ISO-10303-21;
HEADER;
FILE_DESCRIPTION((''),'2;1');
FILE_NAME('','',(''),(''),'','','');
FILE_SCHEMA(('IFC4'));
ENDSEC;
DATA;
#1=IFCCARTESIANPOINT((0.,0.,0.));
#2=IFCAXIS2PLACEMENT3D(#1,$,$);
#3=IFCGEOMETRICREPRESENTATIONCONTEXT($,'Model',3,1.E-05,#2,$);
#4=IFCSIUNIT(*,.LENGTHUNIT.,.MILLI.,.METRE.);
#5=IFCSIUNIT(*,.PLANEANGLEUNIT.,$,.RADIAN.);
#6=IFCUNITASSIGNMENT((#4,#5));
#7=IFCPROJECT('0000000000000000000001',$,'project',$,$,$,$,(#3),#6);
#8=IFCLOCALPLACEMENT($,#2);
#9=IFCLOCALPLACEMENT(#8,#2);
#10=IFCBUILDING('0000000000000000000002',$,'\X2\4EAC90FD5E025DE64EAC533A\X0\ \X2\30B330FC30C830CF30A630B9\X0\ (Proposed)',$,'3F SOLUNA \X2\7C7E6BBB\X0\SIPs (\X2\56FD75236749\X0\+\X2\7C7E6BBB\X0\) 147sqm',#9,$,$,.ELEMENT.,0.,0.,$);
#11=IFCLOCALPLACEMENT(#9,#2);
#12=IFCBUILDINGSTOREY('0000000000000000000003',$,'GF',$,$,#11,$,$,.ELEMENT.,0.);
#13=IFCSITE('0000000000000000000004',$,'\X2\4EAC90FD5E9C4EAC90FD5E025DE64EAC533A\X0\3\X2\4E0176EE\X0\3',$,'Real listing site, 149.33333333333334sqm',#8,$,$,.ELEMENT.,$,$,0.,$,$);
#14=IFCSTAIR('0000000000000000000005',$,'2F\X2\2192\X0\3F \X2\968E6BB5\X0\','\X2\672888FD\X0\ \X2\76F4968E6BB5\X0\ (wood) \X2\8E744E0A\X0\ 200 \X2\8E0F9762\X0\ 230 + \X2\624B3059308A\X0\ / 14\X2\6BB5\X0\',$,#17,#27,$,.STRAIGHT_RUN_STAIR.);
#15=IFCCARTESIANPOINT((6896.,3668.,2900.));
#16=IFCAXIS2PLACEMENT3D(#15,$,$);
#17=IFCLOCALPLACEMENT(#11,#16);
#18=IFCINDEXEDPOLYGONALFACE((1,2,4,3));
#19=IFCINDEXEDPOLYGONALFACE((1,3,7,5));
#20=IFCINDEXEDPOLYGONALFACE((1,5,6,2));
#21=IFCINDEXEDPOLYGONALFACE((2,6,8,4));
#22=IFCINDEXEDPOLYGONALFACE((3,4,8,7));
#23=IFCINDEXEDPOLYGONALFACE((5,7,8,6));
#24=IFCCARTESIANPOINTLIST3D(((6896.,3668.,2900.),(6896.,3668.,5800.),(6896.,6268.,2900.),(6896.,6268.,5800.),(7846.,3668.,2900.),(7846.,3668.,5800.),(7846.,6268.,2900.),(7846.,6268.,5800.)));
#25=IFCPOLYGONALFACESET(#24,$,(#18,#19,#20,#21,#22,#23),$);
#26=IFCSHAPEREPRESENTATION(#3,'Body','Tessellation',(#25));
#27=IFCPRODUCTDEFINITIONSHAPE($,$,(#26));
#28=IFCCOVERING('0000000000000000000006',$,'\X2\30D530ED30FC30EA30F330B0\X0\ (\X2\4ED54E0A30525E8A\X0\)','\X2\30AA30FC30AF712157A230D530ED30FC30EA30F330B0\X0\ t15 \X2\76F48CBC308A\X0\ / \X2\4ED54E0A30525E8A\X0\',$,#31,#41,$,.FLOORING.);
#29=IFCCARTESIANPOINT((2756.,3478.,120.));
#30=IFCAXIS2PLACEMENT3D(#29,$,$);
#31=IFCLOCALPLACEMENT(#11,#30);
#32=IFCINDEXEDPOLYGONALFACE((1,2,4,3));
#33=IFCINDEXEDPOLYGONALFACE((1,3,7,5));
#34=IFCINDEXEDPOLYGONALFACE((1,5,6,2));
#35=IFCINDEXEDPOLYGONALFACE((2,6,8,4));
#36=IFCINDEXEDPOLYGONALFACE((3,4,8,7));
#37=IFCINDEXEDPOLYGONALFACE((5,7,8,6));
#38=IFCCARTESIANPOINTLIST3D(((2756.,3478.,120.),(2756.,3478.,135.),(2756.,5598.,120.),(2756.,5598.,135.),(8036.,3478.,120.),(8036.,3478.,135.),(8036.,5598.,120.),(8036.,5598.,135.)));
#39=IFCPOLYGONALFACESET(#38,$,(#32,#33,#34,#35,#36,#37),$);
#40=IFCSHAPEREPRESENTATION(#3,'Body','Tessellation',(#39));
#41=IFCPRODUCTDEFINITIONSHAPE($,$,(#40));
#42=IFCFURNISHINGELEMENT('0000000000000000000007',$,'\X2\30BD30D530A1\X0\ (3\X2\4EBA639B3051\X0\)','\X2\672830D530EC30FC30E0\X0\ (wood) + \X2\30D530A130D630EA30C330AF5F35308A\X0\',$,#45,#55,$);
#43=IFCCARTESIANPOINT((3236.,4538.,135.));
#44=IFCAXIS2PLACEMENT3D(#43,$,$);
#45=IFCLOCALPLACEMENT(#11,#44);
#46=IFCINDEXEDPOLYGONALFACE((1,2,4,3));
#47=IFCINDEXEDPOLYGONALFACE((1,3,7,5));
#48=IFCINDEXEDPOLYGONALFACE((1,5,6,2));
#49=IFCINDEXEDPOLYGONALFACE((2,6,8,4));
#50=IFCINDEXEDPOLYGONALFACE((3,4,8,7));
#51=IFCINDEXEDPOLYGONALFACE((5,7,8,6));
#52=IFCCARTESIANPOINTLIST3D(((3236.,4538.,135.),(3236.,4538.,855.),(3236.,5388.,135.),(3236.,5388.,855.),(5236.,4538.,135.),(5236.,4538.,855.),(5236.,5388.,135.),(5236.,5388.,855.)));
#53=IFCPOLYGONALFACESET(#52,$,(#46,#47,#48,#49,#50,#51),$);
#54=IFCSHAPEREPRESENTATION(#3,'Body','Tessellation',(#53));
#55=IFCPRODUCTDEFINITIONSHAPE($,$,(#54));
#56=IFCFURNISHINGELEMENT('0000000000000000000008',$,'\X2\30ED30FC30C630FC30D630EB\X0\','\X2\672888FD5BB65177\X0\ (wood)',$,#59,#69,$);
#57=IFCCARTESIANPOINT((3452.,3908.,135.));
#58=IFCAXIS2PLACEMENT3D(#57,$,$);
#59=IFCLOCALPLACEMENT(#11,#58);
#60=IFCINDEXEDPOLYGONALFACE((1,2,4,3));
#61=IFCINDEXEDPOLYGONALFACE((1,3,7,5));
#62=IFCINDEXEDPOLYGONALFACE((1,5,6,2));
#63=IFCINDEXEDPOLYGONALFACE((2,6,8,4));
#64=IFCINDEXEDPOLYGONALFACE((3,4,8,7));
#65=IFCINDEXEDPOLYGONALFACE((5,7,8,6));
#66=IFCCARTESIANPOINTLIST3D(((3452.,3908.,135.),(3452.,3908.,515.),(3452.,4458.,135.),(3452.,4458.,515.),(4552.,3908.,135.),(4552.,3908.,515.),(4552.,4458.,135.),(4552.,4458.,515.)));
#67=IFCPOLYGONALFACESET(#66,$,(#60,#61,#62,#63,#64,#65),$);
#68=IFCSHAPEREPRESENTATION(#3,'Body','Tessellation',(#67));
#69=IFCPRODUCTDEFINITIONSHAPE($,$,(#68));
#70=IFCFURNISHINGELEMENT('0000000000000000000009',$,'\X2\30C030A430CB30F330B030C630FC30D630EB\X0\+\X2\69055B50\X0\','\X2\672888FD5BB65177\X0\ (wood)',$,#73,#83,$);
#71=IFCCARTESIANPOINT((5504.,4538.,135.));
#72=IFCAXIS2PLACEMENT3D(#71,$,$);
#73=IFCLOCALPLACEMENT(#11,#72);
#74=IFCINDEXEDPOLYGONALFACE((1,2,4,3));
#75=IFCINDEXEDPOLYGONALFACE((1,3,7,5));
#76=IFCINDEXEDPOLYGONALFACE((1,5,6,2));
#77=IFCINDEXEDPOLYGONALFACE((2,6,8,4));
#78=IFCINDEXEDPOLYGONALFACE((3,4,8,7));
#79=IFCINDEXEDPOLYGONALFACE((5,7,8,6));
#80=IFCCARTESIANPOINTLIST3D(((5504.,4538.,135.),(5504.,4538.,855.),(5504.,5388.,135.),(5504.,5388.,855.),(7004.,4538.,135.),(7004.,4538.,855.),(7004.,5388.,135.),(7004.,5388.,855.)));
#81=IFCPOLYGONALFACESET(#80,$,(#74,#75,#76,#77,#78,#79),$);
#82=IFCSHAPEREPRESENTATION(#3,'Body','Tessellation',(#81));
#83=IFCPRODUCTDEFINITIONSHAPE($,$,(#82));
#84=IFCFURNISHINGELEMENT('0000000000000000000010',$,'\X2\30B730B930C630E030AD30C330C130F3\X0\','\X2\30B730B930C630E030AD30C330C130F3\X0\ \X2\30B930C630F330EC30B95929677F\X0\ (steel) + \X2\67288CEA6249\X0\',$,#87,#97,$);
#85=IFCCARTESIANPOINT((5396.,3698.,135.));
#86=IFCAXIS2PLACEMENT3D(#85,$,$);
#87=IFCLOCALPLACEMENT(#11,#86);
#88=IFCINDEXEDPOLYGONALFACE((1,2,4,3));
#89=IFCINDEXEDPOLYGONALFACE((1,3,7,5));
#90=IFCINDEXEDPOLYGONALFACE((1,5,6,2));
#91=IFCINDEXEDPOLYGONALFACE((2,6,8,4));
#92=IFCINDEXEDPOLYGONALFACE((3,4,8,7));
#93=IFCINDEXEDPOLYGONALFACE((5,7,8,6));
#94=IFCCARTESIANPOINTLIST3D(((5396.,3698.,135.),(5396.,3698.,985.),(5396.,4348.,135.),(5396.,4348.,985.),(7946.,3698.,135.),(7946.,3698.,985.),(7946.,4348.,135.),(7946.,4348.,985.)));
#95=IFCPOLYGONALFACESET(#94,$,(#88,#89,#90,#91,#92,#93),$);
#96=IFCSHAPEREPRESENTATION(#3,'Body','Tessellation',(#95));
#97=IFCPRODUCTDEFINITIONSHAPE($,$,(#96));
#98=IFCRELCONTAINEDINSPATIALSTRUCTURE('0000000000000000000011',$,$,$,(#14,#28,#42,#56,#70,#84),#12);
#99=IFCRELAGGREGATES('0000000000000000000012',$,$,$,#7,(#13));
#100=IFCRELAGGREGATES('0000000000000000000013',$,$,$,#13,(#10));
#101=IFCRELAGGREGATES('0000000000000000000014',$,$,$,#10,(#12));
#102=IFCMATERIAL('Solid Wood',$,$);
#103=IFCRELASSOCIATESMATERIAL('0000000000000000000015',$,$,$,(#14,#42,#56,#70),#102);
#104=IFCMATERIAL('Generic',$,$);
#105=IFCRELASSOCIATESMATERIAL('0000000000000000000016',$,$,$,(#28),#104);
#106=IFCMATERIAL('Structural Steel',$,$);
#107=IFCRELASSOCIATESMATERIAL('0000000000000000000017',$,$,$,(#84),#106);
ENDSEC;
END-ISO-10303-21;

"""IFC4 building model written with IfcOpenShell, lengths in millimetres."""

from ifc_helpers import new_model, si_unit, frame, frame_2d, origin, place, context, project, spatial, rectangle, extrude, material, element, save


model = new_model("IFC4")

# Units and contexts
model_context = context("Model", 3, precision=1e-05, world=origin())
ifc_project = project(units=[si_unit("LENGTHUNIT", "METRE", prefix="MILLI"), si_unit("PLANEANGLEUNIT", "RADIAN")], contexts=[model_context])

# Site, building, storey
site_placement = place(None, origin())
site = spatial("IfcSite", under=ifc_project, at=site_placement, Name="京都府京都市左京区3丁目3", ObjectType="Real listing site, 149.33333333333334sqm", CompositionType="ELEMENT", RefElevation=0.0)
building_placement = place(site_placement, origin())
building = spatial("IfcBuilding", under=site, at=building_placement, Name="京都市左京区 コートハウス (Proposed)", ObjectType="3F SOLUNA 籾殻SIPs (国産杉+籾殻) 147sqm", CompositionType="ELEMENT", ElevationOfRefHeight=0.0, ElevationOfTerrain=0.0)
storey_placement = place(building_placement, origin())
storey = spatial("IfcBuildingStorey", under=building, at=storey_placement, Name="GF", CompositionType="ELEMENT", Elevation=0.0)

# Shared definitions
ifc_material_1 = material(Name="Solid Wood")
ifc_material_2 = material(Name="Generic")

# Stair
stair_1_placement = place(storey_placement, frame((6896.0, 3668.0, 2900.0)))
element("IfcStair", 1, at=stair_1_placement, inside=storey, material=ifc_material_1, Name="2F→3F 階段", Description="木製 直階段 (wood) 蹴上 200 踏面 230 + 手すり / 14段", PredefinedType="STRAIGHT_RUN_STAIR", context=model_context, shape_type="SweptSolid", body=[
    extrude(rectangle(XDim=950.0, YDim=2600.0, at=frame_2d((475.0, 1300.0))), frame((6896.0, 3668.0, 2900.0)), (0.0, 0.0, 1.0), 2900.0),
])

# Covering
covering_placement = place(storey_placement, frame((2756.0, 3478.0, 120.0)))
element("IfcCovering", 2, at=covering_placement, inside=storey, material=ifc_material_2, Name="フローリング (仕上げ床)", Description="オーク無垢フローリング t15 直貼り / 仕上げ床", PredefinedType="FLOORING", context=model_context, shape_type="SweptSolid", body=[
    extrude(rectangle(XDim=5280.0, YDim=2120.0, at=frame_2d((2640.0, 1060.0))), frame((2756.0, 3478.0, 120.0)), (0.0, 0.0, 1.0), 15.0),
])

# Furnishing elements
furnishing_1_placement = place(storey_placement, frame((3236.0, 4538.0, 135.0)))
element("IfcFurnishingElement", 3, at=furnishing_1_placement, inside=storey, material=ifc_material_1, Name="ソファ (3人掛け)", Description="木フレーム (wood) + ファブリック張り", context=model_context, shape_type="SweptSolid", body=[
    extrude(rectangle(XDim=2000.0, YDim=850.0, at=frame_2d((1000.0, 425.0))), frame((3236.0, 4538.0, 135.0)), (0.0, 0.0, 1.0), 720.0),
])
furnishing_2_placement = place(storey_placement, frame((3452.0, 3908.0, 135.0)))
element("IfcFurnishingElement", 4, at=furnishing_2_placement, inside=storey, material=ifc_material_1, Name="ローテーブル", Description="木製家具 (wood)", context=model_context, shape_type="SweptSolid", body=[
    extrude(rectangle(XDim=1100.0, YDim=550.0, at=frame_2d((550.0, 275.0))), frame((3452.0, 3908.0, 135.0)), (0.0, 0.0, 1.0), 380.0),
])
furnishing_3_placement = place(storey_placement, frame((5504.0, 4538.0, 135.0)))
element("IfcFurnishingElement", 5, at=furnishing_3_placement, inside=storey, material=ifc_material_1, Name="ダイニングテーブル+椅子", Description="木製家具 (wood)", context=model_context, shape_type="SweptSolid", body=[
    extrude(rectangle(XDim=1500.0, YDim=850.0, at=frame_2d((750.0, 425.0))), frame((5504.0, 4538.0, 135.0)), (0.0, 0.0, 1.0), 720.0),
])
ifc_material_3 = material(Name="Structural Steel")
furnishing_4_placement = place(storey_placement, frame((5396.0, 3698.0, 135.0)))
element("IfcFurnishingElement", 6, at=furnishing_4_placement, inside=storey, material=ifc_material_3, Name="システムキッチン", Description="システムキッチン ステンレス天板 (steel) + 木質扉", context=model_context, shape_type="SweptSolid", body=[
    extrude(rectangle(XDim=2550.0, YDim=650.0, at=frame_2d((1275.0, 325.0))), frame((5396.0, 3698.0, 135.0)), (0.0, 0.0, 1.0), 850.0),
])

save(model, "model.ifc")
